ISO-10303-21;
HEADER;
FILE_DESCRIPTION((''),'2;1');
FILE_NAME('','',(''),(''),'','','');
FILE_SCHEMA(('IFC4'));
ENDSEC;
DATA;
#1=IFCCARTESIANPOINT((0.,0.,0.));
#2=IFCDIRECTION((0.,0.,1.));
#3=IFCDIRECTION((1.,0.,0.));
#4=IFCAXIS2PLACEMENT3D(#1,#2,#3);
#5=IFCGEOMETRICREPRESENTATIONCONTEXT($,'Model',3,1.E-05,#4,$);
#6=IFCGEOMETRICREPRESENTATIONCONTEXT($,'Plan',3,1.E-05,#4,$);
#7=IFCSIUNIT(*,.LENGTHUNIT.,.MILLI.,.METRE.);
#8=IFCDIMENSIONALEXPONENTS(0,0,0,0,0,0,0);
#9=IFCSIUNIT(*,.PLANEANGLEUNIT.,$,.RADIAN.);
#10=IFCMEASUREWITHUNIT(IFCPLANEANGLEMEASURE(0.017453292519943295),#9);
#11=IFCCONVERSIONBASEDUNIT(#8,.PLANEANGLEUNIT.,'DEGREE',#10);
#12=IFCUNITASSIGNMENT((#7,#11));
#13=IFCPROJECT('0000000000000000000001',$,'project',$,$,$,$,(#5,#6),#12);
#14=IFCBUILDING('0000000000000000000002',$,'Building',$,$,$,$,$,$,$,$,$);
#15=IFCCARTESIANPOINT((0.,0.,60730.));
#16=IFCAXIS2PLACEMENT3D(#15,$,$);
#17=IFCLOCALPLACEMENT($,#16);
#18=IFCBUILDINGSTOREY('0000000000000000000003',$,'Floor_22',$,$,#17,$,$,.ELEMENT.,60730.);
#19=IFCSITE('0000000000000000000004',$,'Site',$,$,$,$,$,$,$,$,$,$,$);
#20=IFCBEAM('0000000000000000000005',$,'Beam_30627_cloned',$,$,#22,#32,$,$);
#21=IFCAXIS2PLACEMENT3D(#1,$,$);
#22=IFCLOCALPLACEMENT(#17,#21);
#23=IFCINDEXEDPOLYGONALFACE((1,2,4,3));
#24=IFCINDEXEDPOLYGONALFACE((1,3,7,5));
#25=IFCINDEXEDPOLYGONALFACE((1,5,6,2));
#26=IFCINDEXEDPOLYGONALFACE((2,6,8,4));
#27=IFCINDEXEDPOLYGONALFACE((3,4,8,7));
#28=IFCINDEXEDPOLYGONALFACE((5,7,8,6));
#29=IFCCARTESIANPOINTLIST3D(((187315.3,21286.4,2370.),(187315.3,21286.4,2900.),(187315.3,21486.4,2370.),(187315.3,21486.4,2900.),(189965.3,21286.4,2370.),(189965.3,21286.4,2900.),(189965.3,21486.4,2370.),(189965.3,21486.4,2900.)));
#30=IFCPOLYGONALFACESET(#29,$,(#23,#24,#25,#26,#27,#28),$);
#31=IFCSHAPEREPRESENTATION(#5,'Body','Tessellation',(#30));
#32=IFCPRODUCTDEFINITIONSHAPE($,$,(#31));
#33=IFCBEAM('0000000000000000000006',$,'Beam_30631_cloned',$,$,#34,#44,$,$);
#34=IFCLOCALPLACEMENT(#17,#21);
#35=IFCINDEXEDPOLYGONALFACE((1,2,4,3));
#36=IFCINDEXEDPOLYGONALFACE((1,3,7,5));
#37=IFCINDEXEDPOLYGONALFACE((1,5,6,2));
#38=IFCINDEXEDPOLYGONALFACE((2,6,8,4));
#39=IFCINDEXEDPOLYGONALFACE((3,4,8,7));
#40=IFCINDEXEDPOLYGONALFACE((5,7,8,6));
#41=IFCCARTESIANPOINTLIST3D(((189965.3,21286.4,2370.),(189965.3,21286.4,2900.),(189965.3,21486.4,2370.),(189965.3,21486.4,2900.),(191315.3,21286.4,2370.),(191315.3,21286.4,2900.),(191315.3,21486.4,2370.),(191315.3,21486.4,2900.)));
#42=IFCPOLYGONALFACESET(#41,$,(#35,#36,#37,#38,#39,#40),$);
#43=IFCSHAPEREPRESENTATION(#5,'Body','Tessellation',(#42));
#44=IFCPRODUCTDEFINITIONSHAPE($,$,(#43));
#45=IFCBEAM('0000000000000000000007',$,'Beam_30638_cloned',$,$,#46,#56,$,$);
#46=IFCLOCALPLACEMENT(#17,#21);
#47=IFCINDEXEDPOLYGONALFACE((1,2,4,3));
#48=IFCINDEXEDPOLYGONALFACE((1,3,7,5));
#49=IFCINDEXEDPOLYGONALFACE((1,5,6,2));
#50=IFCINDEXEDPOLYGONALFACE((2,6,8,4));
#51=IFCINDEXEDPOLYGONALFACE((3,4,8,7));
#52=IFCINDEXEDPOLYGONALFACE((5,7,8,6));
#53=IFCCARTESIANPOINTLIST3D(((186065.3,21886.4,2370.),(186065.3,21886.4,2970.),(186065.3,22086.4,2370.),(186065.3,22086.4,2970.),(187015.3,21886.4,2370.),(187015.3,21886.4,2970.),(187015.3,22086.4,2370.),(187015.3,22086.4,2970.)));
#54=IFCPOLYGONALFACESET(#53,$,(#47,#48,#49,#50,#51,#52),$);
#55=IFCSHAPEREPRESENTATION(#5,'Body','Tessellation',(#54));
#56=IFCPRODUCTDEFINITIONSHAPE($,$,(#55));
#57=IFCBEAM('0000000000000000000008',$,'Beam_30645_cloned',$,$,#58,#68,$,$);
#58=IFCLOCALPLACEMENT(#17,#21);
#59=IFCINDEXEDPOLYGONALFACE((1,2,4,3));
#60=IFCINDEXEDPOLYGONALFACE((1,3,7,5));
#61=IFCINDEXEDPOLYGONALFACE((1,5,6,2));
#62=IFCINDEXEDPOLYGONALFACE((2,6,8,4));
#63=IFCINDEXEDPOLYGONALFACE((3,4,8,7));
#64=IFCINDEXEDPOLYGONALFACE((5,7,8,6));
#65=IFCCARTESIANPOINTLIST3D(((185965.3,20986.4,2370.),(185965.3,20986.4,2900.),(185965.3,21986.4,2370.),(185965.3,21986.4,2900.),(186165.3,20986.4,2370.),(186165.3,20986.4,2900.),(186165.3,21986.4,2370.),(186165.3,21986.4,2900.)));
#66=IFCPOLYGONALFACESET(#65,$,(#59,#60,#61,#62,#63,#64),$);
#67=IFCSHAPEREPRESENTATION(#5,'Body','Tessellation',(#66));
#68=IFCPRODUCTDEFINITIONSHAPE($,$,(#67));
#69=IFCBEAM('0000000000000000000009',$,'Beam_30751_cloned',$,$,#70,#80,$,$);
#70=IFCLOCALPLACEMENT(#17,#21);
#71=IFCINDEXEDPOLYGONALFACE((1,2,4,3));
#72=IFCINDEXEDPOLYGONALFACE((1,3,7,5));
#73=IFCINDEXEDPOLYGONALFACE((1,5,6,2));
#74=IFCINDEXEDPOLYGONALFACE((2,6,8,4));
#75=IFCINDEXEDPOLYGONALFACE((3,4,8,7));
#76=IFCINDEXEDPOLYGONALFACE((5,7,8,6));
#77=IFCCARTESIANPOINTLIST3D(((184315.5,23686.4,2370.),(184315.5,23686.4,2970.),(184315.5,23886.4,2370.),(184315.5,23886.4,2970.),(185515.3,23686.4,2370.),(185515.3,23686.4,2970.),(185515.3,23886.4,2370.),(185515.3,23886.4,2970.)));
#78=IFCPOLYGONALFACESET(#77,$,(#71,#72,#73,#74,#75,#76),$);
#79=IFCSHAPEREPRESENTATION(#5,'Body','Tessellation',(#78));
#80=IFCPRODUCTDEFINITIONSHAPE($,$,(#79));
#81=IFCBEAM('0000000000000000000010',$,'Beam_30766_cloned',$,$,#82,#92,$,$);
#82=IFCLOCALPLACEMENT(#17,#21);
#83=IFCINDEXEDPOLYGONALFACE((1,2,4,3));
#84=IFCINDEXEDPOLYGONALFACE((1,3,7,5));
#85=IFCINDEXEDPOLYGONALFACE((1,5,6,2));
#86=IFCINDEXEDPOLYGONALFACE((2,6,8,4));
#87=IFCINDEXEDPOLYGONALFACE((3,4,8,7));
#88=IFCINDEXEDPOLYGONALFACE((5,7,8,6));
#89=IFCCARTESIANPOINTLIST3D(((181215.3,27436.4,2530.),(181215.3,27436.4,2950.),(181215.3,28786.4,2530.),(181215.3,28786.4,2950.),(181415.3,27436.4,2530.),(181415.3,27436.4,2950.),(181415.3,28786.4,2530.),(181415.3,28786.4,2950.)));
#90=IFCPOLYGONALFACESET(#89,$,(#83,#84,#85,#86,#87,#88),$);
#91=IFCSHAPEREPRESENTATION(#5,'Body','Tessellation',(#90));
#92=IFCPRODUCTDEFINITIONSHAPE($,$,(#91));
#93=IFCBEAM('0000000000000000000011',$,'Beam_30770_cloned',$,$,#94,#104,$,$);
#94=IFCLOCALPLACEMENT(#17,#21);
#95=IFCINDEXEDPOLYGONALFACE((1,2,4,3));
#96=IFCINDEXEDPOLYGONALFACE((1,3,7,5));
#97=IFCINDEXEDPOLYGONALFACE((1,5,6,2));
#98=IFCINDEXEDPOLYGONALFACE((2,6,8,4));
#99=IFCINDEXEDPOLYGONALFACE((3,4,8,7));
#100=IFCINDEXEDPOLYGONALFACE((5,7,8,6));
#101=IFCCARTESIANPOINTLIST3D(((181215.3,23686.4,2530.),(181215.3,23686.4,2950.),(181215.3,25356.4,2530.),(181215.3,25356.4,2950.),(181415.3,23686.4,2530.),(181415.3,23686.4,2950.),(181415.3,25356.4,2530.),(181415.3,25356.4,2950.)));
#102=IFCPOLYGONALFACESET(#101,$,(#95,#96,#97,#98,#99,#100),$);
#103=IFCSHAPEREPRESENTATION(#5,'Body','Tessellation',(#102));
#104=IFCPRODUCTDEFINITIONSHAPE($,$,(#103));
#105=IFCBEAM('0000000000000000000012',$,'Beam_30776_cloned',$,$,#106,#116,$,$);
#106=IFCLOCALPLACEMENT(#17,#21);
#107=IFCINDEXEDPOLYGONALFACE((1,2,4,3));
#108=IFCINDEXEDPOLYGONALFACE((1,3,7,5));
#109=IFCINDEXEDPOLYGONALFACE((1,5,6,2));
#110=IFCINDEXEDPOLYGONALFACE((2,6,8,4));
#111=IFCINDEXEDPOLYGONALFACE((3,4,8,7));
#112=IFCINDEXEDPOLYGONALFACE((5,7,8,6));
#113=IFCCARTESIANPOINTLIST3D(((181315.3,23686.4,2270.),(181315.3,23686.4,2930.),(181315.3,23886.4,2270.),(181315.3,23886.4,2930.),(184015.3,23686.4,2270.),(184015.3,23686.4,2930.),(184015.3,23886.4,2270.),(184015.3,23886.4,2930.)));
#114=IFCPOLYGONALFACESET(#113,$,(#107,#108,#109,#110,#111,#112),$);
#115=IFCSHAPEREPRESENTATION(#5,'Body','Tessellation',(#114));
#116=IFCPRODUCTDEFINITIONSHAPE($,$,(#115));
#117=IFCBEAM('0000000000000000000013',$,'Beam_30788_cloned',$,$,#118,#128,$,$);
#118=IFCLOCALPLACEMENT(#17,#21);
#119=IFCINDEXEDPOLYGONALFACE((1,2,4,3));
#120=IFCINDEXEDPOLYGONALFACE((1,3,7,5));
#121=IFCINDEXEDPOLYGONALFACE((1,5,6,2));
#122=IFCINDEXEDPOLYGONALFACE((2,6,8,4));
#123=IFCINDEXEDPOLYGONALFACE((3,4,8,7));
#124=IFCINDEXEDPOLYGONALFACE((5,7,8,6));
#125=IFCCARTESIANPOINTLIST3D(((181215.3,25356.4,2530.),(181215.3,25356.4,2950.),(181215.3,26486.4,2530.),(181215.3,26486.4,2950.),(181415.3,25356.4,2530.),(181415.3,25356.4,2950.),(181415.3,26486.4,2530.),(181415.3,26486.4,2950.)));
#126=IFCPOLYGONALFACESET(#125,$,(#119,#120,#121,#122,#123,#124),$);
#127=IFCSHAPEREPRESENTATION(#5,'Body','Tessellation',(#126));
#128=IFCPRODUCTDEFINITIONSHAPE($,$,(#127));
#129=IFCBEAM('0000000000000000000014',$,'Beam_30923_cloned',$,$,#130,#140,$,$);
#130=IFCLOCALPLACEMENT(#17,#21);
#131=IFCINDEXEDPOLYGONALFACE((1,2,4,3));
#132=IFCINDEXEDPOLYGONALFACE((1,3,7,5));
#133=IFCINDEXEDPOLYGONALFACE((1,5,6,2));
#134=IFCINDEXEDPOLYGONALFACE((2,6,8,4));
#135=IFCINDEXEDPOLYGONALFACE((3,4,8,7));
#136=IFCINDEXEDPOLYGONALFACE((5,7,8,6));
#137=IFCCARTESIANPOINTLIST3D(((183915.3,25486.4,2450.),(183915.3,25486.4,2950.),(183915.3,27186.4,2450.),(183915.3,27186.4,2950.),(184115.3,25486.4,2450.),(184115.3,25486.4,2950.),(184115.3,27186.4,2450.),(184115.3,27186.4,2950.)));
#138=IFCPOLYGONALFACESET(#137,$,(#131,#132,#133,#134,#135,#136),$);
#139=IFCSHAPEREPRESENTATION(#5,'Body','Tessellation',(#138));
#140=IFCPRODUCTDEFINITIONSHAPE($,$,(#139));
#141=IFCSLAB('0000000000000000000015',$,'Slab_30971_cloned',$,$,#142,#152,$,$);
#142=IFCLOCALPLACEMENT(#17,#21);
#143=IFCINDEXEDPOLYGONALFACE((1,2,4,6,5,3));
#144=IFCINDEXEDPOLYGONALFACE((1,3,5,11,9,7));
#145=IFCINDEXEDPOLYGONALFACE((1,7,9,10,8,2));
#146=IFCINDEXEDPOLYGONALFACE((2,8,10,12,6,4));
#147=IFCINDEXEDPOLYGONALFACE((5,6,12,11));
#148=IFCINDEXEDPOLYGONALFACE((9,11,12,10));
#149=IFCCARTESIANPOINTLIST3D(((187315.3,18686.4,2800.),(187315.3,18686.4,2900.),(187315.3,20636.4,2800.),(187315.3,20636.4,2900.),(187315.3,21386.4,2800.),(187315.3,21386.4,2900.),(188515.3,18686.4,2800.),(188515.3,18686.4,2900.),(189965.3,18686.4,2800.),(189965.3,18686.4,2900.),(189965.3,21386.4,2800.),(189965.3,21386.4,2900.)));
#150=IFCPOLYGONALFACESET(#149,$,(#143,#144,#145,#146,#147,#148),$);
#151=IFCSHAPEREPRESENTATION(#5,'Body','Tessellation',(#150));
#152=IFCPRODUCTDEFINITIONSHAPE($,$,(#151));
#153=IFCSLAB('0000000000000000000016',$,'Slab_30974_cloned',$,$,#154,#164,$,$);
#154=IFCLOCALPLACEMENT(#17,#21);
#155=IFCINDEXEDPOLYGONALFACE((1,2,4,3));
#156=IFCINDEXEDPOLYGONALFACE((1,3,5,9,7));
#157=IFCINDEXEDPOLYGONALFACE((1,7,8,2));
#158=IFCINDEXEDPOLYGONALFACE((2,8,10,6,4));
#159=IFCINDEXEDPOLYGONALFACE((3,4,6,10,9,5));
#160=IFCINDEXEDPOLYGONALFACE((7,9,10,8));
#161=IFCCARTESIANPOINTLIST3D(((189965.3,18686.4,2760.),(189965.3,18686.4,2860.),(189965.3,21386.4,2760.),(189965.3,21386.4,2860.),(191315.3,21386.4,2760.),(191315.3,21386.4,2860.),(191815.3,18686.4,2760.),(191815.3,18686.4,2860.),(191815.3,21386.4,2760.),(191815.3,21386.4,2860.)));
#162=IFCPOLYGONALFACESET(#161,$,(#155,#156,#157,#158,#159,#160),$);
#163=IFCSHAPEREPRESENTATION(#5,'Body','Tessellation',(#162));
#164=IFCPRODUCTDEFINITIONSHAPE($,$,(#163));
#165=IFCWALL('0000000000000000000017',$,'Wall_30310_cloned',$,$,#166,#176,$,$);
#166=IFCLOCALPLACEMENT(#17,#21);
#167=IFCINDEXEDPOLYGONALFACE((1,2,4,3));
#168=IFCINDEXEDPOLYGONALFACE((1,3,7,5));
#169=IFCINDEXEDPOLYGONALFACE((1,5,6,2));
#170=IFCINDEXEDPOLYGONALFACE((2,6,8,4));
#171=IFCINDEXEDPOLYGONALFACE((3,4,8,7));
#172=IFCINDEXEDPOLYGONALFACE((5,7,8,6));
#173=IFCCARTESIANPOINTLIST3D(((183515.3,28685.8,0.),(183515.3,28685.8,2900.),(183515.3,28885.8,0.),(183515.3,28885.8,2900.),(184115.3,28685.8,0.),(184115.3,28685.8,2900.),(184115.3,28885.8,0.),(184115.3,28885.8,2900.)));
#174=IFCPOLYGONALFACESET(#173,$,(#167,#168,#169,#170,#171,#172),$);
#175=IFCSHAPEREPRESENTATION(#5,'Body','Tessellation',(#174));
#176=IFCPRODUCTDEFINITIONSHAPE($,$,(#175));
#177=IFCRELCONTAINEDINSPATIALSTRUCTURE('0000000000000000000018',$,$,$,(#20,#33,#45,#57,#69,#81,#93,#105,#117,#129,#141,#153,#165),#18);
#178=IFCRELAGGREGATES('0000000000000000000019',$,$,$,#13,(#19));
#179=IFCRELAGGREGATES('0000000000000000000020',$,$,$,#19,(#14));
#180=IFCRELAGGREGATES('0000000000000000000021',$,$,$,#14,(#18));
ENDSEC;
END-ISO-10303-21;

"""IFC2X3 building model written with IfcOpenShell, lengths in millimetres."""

from ifc_helpers import new_model, entity, si_unit, converted_unit, frame, origin_with_axes, origin_2d, place, context, project, spatial, polyline, rectangle, outline, extrude, source, transform, mapped, element, save


model = new_model("IFC2X3")

# Units and contexts
model_context = context("Model", 3, precision=1e-05, world=origin_with_axes())
plan_context = context("Plan", 3, precision=1e-05, world=origin_with_axes())
ifc_project = project(units=[si_unit("LENGTHUNIT", "METRE", prefix="MILLI"), converted_unit("PLANEANGLEUNIT", "DEGREE", entity("IfcPlaneAngleMeasure", 0.017453292519943295), si_unit("PLANEANGLEUNIT", "RADIAN"), dimensions=[0, 0, 0, 0, 0, 0, 0])], contexts=[model_context, plan_context])

# Site, building, storey
site = spatial("IfcSite", under=ifc_project, Name="Site")
building = spatial("IfcBuilding", under=site, Name="Building")
storey_placement = place(None, frame((0.0, 0.0, 60730.0)))
storey = spatial("IfcBuildingStorey", under=building, at=storey_placement, Name="Floor_22", CompositionType="ELEMENT", Elevation=60730.0)

# Beams
shared_shape_1 = source(origin_with_axes(), model_context, "Body", "SweptSolid", [
    extrude(rectangle(XDim=200.0, YDim=530.0, at=origin_2d()), origin_with_axes(), (0.0, 0.0, 1.0), 2650.0),
])
beam_1_placement = place(storey_placement, frame((187315.3, 21386.4, 2635.0), z_axis=(2650.0, 0.0, 0.0), x_axis=(0.0, -2650.0, 0.0)))
element("IfcBeam", 1, at=beam_1_placement, inside=storey, Name="Beam_30627_cloned", context=model_context, shape_type="MappedRepresentation", body=[
    mapped(shared_shape_1, transform((0.0, 0.0, 0.0), x_axis=(1.0, 0.0, 0.0), y_axis=(0.0, 1.0, 0.0), z_axis=(0.0, 0.0, 1.0), scale=1.0)),
])
shared_shape_2 = source(origin_with_axes(), model_context, "Body", "SweptSolid", [
    extrude(rectangle(XDim=200.0, YDim=530.0, at=origin_2d()), origin_with_axes(), (0.0, 0.0, 1.0), 1350.0),
])
beam_2_placement = place(storey_placement, frame((189965.3, 21386.4, 2635.0), z_axis=(1350.0, 0.0, 0.0), x_axis=(0.0, -1350.0, 0.0)))
element("IfcBeam", 2, at=beam_2_placement, inside=storey, Name="Beam_30631_cloned", context=model_context, shape_type="MappedRepresentation", body=[
    mapped(shared_shape_2, transform((0.0, 0.0, 0.0), x_axis=(1.0, 0.0, 0.0), y_axis=(0.0, 1.0, 0.0), z_axis=(0.0, 0.0, 1.0), scale=1.0)),
])
shared_shape_3 = source(origin_with_axes(), model_context, "Body", "SweptSolid", [
    extrude(rectangle(XDim=200.0, YDim=600.0, at=origin_2d()), origin_with_axes(), (0.0, 0.0, 1.0), 950.0),
])
beam_3_placement = place(storey_placement, frame((186065.3, 21986.4, 2670.0), z_axis=(950.0, 0.0, 0.0), x_axis=(0.0, -950.0, 0.0)))
element("IfcBeam", 3, at=beam_3_placement, inside=storey, Name="Beam_30638_cloned", context=model_context, shape_type="MappedRepresentation", body=[
    mapped(shared_shape_3, transform((0.0, 0.0, 0.0), x_axis=(1.0, 0.0, 0.0), y_axis=(0.0, 1.0, 0.0), z_axis=(0.0, 0.0, 1.0), scale=1.0)),
])
shared_shape_4 = source(origin_with_axes(), model_context, "Body", "SweptSolid", [
    extrude(rectangle(XDim=200.0, YDim=530.0, at=origin_2d()), origin_with_axes(), (0.0, 0.0, 1.0), 1000.0),
])
beam_4_placement = place(storey_placement, frame((186065.3, 20986.4, 2635.0), z_axis=(0.0, 1000.0, 0.0), x_axis=(1000.0, 0.0, 0.0)))
element("IfcBeam", 4, at=beam_4_placement, inside=storey, Name="Beam_30645_cloned", context=model_context, shape_type="MappedRepresentation", body=[
    mapped(shared_shape_4, transform((0.0, 0.0, 0.0), x_axis=(1.0, 0.0, 0.0), y_axis=(0.0, 1.0, 0.0), z_axis=(0.0, 0.0, 1.0), scale=1.0)),
])
shared_shape_5 = source(origin_with_axes(), model_context, "Body", "SweptSolid", [
    extrude(rectangle(XDim=200.0, YDim=600.0, at=origin_2d()), origin_with_axes(), (0.0, 0.0, 1.0), 1199.9),
])
beam_5_placement = place(storey_placement, frame((184315.5, 23786.4, 2670.0), z_axis=(1199.853373, 0.000009, 0.0), x_axis=(0.000009, -1199.853373, 0.0)))
element("IfcBeam", 5, at=beam_5_placement, inside=storey, Name="Beam_30751_cloned", context=model_context, shape_type="MappedRepresentation", body=[
    mapped(shared_shape_5, transform((0.0, 0.0, 0.0), x_axis=(1.0, 0.0, 0.0), y_axis=(0.0, 1.0, 0.0), z_axis=(0.0, 0.0, 1.0), scale=1.0)),
])
shared_shape_6 = source(origin_with_axes(), model_context, "Body", "SweptSolid", [
    extrude(rectangle(XDim=200.0, YDim=420.0, at=origin_2d()), origin_with_axes(), (0.0, 0.0, 1.0), 1350.0),
])
beam_6_placement = place(storey_placement, frame((181315.3, 27436.4, 2740.0), z_axis=(0.0, 1350.0, 0.0), x_axis=(1350.0, 0.0, 0.0)))
element("IfcBeam", 6, at=beam_6_placement, inside=storey, Name="Beam_30766_cloned", context=model_context, shape_type="MappedRepresentation", body=[
    mapped(shared_shape_6, transform((0.0, 0.0, 0.0), x_axis=(1.0, 0.0, 0.0), y_axis=(0.0, 1.0, 0.0), z_axis=(0.0, 0.0, 1.0), scale=1.0)),
])
shared_shape_7 = source(origin_with_axes(), model_context, "Body", "SweptSolid", [
    extrude(rectangle(XDim=200.0, YDim=420.0, at=origin_2d()), origin_with_axes(), (0.0, 0.0, 1.0), 1670.0),
])
beam_7_placement = place(storey_placement, frame((181315.3, 23686.4, 2740.0), z_axis=(0.0, 1669.999995, 0.0), x_axis=(1669.999995, 0.0, 0.0)))
element("IfcBeam", 7, at=beam_7_placement, inside=storey, Name="Beam_30770_cloned", context=model_context, shape_type="MappedRepresentation", body=[
    mapped(shared_shape_7, transform((0.0, 0.0, 0.0), x_axis=(1.0, 0.0, 0.0), y_axis=(0.0, 1.0, 0.0), z_axis=(0.0, 0.0, 1.0), scale=1.0)),
])
shared_shape_8 = source(origin_with_axes(), model_context, "Body", "SweptSolid", [
    extrude(rectangle(XDim=200.0, YDim=660.0, at=origin_2d()), origin_with_axes(), (0.0, 0.0, 1.0), 2700.0),
])
beam_8_placement = place(storey_placement, frame((181315.3, 23786.4, 2600.0), z_axis=(2700.0, -0.000001, 0.0), x_axis=(-0.000001, -2700.0, 0.0)))
element("IfcBeam", 8, at=beam_8_placement, inside=storey, Name="Beam_30776_cloned", context=model_context, shape_type="MappedRepresentation", body=[
    mapped(shared_shape_8, transform((0.0, 0.0, 0.0), x_axis=(1.0, 0.0, 0.0), y_axis=(0.0, 1.0, 0.0), z_axis=(0.0, 0.0, 1.0), scale=1.0)),
])
shared_shape_9 = source(origin_with_axes(), model_context, "Body", "SweptSolid", [
    extrude(rectangle(XDim=200.0, YDim=420.0, at=origin_2d()), origin_with_axes(), (0.0, 0.0, 1.0), 1130.0),
])
beam_9_placement = place(storey_placement, frame((181315.3, 25356.4, 2740.0), z_axis=(0.0, 1130.0, 0.0), x_axis=(1130.0, 0.0, 0.0)))
element("IfcBeam", 9, at=beam_9_placement, inside=storey, Name="Beam_30788_cloned", context=model_context, shape_type="MappedRepresentation", body=[
    mapped(shared_shape_9, transform((0.0, 0.0, 0.0), x_axis=(1.0, 0.0, 0.0), y_axis=(0.0, 1.0, 0.0), z_axis=(0.0, 0.0, 1.0), scale=1.0)),
])
shared_shape_10 = source(origin_with_axes(), model_context, "Body", "SweptSolid", [
    extrude(rectangle(XDim=200.0, YDim=500.0, at=origin_2d()), origin_with_axes(), (0.0, 0.0, 1.0), 1700.0),
])
beam_10_placement = place(storey_placement, frame((184015.3, 25486.4, 2700.0), z_axis=(0.0, 1700.000002, 0.0), x_axis=(1700.000002, 0.0, 0.0)))
element("IfcBeam", 10, at=beam_10_placement, inside=storey, Name="Beam_30923_cloned", context=model_context, shape_type="MappedRepresentation", body=[
    mapped(shared_shape_10, transform((0.0, 0.0, 0.0), x_axis=(1.0, 0.0, 0.0), y_axis=(0.0, 1.0, 0.0), z_axis=(0.0, 0.0, 1.0), scale=1.0)),
])

# Slabs
shared_shape_11 = source(origin_with_axes(), model_context, "Body", "SweptSolid", [
    extrude(outline(polyline([(0.0, 0.0), (750.0, 0.0), (2700.0, 0.0), (2700.0, 1200.0), (2700.0, 2650.0), (0.0, 2650.0)])), origin_with_axes(), (0.0, 0.0, 1.0), 100.0),
])
slab_1_placement = place(storey_placement, frame((187315.3, 21386.4, 2800.0), z_axis=(0.0, 0.0, 1.0), x_axis=(0.0, -750.0, 0.0)))
element("IfcSlab", 11, at=slab_1_placement, inside=storey, Name="Slab_30971_cloned", context=model_context, shape_type="MappedRepresentation", body=[
    mapped(shared_shape_11, transform((0.0, 0.0, 0.0), x_axis=(1.0, 0.0, 0.0), y_axis=(0.0, 1.0, 0.0), z_axis=(0.0, 0.0, 1.0), scale=1.0)),
])
shared_shape_12 = source(origin_with_axes(), model_context, "Body", "SweptSolid", [
    extrude(outline(polyline([(0.0, 0.0), (2700.0, 0.0), (2700.0, 1850.0), (0.0, 1850.0), (0.0, 1350.0)])), origin_with_axes(), (0.0, 0.0, 1.0), 100.0),
])
slab_2_placement = place(storey_placement, frame((189965.3, 21386.4, 2760.0), z_axis=(0.0, 0.0, 1.0), x_axis=(0.0, -2700.0, 0.0)))
element("IfcSlab", 12, at=slab_2_placement, inside=storey, Name="Slab_30974_cloned", context=model_context, shape_type="MappedRepresentation", body=[
    mapped(shared_shape_12, transform((0.0, 0.0, 0.0), x_axis=(1.0, 0.0, 0.0), y_axis=(0.0, 1.0, 0.0), z_axis=(0.0, 0.0, 1.0), scale=1.0)),
])

# Wall
shared_shape_13 = source(origin_with_axes(), model_context, "Body", "SweptSolid", [
    extrude(rectangle(XDim=600.0, YDim=200.0, at=origin_2d()), origin_with_axes(), (0.0, 0.0, 1.0), 2900.0),
])
wall_1_placement = place(storey_placement, frame((183815.3, 28785.8, 0.0), z_axis=(0.0, 0.0, 1.0), x_axis=(600.0, 0.0, 0.0)))
element("IfcWall", 13, at=wall_1_placement, inside=storey, Name="Wall_30310_cloned", context=model_context, shape_type="MappedRepresentation", body=[
    mapped(shared_shape_13, transform((0.0, 0.0, 0.0), x_axis=(1.0, 0.0, 0.0), y_axis=(0.0, 1.0, 0.0), z_axis=(0.0, 0.0, 1.0), scale=1.0)),
])

save(model, "model.ifc")
